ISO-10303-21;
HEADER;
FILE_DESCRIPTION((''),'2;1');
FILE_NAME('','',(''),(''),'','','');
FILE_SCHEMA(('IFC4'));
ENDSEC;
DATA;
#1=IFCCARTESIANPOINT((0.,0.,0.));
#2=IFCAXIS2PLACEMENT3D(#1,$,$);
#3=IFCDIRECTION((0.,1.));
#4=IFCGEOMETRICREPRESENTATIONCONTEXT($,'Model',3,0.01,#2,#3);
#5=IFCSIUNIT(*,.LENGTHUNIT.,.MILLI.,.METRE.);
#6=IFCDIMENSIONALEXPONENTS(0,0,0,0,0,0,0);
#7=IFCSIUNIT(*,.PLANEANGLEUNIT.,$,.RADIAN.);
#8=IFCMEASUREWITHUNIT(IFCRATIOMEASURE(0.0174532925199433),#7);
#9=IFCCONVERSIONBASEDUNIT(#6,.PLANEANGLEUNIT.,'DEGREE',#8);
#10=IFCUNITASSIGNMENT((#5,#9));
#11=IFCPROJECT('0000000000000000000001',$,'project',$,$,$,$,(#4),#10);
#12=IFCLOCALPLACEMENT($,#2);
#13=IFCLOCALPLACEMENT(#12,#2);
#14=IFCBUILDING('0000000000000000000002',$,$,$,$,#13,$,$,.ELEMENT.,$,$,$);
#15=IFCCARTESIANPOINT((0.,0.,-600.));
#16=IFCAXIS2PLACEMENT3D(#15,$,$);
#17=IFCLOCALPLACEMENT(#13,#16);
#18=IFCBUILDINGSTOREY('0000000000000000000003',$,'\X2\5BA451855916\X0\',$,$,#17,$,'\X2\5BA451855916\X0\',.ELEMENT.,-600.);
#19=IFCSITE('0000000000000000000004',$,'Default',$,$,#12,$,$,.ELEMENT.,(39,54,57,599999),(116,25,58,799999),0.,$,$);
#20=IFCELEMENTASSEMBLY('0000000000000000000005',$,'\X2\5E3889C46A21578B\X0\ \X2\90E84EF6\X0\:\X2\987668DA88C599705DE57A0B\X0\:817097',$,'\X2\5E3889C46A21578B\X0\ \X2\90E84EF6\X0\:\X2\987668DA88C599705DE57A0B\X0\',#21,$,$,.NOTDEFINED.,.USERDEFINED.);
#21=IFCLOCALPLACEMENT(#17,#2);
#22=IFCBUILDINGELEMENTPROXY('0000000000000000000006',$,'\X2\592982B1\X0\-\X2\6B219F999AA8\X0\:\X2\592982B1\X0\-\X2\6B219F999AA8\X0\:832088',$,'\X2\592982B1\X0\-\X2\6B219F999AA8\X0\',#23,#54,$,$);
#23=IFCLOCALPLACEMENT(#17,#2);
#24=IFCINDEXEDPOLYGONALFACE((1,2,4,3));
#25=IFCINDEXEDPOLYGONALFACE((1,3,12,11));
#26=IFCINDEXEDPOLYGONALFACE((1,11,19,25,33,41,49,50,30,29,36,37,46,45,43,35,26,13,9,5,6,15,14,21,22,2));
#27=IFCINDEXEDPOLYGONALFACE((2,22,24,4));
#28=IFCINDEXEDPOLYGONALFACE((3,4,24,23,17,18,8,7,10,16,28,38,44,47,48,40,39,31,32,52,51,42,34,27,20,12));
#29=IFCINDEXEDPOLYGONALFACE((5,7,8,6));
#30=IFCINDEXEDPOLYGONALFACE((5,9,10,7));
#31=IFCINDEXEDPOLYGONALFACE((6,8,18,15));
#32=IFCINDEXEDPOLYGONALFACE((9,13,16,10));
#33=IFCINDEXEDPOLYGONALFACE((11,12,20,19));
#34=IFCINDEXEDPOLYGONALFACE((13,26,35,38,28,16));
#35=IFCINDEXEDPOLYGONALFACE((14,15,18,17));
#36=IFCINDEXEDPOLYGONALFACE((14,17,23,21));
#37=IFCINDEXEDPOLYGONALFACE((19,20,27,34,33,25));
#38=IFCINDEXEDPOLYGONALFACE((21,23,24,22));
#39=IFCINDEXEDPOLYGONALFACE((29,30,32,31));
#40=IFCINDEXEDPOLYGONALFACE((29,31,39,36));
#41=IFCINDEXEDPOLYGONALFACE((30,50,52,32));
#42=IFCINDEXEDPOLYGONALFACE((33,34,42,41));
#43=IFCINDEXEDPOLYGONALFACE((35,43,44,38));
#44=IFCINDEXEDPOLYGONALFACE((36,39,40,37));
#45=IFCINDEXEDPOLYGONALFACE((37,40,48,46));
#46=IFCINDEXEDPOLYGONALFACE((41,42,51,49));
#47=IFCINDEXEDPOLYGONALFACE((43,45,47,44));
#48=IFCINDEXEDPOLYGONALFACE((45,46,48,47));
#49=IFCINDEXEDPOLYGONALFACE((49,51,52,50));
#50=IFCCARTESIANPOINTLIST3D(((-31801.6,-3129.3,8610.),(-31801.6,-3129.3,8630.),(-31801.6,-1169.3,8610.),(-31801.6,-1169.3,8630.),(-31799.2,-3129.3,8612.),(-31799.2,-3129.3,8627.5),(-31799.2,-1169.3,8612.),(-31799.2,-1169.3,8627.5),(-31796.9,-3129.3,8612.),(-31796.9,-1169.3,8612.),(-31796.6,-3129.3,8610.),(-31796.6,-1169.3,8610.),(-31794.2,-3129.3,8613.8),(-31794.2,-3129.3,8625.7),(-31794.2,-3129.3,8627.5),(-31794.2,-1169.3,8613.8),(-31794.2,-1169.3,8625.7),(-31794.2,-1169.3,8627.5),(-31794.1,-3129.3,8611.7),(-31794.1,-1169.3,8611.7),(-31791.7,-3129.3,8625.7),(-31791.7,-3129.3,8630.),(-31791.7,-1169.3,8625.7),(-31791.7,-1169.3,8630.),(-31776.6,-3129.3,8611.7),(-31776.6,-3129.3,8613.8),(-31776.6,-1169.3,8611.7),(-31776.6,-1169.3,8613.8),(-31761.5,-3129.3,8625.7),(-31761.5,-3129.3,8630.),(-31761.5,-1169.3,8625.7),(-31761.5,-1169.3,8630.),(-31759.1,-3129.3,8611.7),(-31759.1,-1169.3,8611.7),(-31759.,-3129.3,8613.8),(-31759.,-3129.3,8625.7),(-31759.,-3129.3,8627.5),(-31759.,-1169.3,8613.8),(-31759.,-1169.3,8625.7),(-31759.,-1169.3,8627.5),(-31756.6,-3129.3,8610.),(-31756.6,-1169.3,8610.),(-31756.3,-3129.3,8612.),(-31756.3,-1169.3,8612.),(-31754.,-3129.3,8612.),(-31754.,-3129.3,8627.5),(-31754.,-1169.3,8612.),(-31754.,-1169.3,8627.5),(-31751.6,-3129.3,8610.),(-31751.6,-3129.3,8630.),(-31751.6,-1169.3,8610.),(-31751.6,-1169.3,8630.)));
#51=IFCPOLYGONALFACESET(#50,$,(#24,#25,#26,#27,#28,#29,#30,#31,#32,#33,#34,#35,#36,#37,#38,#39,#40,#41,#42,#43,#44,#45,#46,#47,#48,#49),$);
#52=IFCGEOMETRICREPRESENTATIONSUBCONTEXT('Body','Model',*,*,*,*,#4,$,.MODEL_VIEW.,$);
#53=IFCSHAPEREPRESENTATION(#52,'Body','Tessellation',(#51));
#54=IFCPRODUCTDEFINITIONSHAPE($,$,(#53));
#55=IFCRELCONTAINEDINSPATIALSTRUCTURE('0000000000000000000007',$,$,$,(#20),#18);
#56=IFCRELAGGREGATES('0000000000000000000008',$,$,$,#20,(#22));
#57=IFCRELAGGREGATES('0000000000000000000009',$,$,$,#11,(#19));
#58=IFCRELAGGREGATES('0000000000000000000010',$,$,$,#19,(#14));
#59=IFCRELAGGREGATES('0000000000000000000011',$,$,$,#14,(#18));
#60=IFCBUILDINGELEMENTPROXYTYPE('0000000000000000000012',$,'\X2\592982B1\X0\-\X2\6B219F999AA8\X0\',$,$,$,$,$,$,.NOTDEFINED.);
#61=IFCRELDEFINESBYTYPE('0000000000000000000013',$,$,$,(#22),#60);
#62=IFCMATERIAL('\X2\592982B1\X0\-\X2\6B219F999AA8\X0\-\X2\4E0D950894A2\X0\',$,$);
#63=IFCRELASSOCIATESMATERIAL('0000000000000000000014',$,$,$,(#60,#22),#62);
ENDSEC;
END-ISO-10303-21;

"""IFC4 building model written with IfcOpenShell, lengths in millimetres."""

from ifc_helpers import new_model, entity, si_unit, converted_unit, direction, frame, origin, place, context, subcontext, project, spatial, polyline, outline, extrude, source, transform, mapped, material, type_object, type_shapes, element, aggregate, save


model = new_model("IFC4")

# Units and contexts
model_context = context("Model", 3, precision=0.01, world=origin(), true_north=direction((0.0, 1.0)))
body_context = subcontext(model_context, "Body", "Model", "MODEL_VIEW")
ifc_project = project(units=[si_unit("LENGTHUNIT", "METRE", prefix="MILLI"), converted_unit("PLANEANGLEUNIT", "DEGREE", entity("IfcRatioMeasure", 0.0174532925199433), si_unit("PLANEANGLEUNIT", "RADIAN"), dimensions=[0, 0, 0, 0, 0, 0, 0])], contexts=[model_context])

# Site, building, storey
site_placement = place(None, origin())
site = spatial("IfcSite", under=ifc_project, at=site_placement, Name="Default", CompositionType="ELEMENT", RefLatitude=(39, 54, 57, 599999), RefLongitude=(116, 25, 58, 799999), RefElevation=0.0)
building_placement = place(site_placement, origin())
building = spatial("IfcBuilding", under=site, at=building_placement, CompositionType="ELEMENT")
storey_placement = place(building_placement, frame((0.0, 0.0, -600.0)))
storey = spatial("IfcBuildingStorey", under=building, at=storey_placement, Name="室内外", LongName="室内外", CompositionType="ELEMENT", Elevation=-600.0)

# Element assembly, building element proxy
assembly_placement = place(storey_placement, origin())
assembly = element("IfcElementAssembly", 1, at=assembly_placement, inside=storey, Name="常规模型 部件:顶棚装饰工程:817097", ObjectType="常规模型 部件:顶棚装饰工程", AssemblyPlace="NOTDEFINED", PredefinedType="USERDEFINED")
ifc_material_1 = material(Name="天花-次龙骨-不锈钢")
building_element_proxy_type_1 = type_object("IfcBuildingElementProxyType", Name="天花-次龙骨", PredefinedType="NOTDEFINED", material=ifc_material_1)
shared_shape_1 = source(origin(), body_context, "Body", "SweptSolid", [
    extrude(outline(polyline([(-25.0, -9.1), (-20.0, -9.1), (-17.5, -7.4), (0.0, -7.4), (17.5, -7.4), (20.0, -9.1), (25.0, -9.1), (25.0, 10.9), (15.1, 10.9), (15.1, 6.6), (17.6, 6.6), (17.6, 8.4), (22.6, 8.4), (22.6, -7.1), (20.3, -7.1), (17.6, -5.3), (0.0, -5.3), (-17.6, -5.3), (-20.3, -7.1), (-22.6, -7.1), (-22.6, 8.4), (-17.6, 8.4), (-17.6, 6.6), (-15.1, 6.6), (-15.1, 10.9), (-25.0, 10.9), (-25.0, -9.1)])), frame((0.0, 0.0, -0.9), z_axis=(1.0, 0.0, 0.0), x_axis=(0.0, 1.0, 0.0)), (0.0, 0.0, 1.0), 1960.0),
])
type_shapes(building_element_proxy_type_1, [shared_shape_1])
proxy_1_placement = place(assembly_placement, frame((-31776.6, -1169.3, 8620.0), z_axis=(0.0, 0.0, 1.0), x_axis=(0.0, -1.0, 0.0)))
proxy_1 = element("IfcBuildingElementProxy", 2, at=proxy_1_placement, type_object=building_element_proxy_type_1, material=ifc_material_1, Name="天花-次龙骨:天花-次龙骨:832088", ObjectType="天花-次龙骨", context=body_context, shape_type="MappedRepresentation", body=[
    mapped(shared_shape_1, transform((0.0, 0.0, 0.0), scale=1.0)),
])
aggregate(assembly, [proxy_1])

save(model, "model.ifc")
